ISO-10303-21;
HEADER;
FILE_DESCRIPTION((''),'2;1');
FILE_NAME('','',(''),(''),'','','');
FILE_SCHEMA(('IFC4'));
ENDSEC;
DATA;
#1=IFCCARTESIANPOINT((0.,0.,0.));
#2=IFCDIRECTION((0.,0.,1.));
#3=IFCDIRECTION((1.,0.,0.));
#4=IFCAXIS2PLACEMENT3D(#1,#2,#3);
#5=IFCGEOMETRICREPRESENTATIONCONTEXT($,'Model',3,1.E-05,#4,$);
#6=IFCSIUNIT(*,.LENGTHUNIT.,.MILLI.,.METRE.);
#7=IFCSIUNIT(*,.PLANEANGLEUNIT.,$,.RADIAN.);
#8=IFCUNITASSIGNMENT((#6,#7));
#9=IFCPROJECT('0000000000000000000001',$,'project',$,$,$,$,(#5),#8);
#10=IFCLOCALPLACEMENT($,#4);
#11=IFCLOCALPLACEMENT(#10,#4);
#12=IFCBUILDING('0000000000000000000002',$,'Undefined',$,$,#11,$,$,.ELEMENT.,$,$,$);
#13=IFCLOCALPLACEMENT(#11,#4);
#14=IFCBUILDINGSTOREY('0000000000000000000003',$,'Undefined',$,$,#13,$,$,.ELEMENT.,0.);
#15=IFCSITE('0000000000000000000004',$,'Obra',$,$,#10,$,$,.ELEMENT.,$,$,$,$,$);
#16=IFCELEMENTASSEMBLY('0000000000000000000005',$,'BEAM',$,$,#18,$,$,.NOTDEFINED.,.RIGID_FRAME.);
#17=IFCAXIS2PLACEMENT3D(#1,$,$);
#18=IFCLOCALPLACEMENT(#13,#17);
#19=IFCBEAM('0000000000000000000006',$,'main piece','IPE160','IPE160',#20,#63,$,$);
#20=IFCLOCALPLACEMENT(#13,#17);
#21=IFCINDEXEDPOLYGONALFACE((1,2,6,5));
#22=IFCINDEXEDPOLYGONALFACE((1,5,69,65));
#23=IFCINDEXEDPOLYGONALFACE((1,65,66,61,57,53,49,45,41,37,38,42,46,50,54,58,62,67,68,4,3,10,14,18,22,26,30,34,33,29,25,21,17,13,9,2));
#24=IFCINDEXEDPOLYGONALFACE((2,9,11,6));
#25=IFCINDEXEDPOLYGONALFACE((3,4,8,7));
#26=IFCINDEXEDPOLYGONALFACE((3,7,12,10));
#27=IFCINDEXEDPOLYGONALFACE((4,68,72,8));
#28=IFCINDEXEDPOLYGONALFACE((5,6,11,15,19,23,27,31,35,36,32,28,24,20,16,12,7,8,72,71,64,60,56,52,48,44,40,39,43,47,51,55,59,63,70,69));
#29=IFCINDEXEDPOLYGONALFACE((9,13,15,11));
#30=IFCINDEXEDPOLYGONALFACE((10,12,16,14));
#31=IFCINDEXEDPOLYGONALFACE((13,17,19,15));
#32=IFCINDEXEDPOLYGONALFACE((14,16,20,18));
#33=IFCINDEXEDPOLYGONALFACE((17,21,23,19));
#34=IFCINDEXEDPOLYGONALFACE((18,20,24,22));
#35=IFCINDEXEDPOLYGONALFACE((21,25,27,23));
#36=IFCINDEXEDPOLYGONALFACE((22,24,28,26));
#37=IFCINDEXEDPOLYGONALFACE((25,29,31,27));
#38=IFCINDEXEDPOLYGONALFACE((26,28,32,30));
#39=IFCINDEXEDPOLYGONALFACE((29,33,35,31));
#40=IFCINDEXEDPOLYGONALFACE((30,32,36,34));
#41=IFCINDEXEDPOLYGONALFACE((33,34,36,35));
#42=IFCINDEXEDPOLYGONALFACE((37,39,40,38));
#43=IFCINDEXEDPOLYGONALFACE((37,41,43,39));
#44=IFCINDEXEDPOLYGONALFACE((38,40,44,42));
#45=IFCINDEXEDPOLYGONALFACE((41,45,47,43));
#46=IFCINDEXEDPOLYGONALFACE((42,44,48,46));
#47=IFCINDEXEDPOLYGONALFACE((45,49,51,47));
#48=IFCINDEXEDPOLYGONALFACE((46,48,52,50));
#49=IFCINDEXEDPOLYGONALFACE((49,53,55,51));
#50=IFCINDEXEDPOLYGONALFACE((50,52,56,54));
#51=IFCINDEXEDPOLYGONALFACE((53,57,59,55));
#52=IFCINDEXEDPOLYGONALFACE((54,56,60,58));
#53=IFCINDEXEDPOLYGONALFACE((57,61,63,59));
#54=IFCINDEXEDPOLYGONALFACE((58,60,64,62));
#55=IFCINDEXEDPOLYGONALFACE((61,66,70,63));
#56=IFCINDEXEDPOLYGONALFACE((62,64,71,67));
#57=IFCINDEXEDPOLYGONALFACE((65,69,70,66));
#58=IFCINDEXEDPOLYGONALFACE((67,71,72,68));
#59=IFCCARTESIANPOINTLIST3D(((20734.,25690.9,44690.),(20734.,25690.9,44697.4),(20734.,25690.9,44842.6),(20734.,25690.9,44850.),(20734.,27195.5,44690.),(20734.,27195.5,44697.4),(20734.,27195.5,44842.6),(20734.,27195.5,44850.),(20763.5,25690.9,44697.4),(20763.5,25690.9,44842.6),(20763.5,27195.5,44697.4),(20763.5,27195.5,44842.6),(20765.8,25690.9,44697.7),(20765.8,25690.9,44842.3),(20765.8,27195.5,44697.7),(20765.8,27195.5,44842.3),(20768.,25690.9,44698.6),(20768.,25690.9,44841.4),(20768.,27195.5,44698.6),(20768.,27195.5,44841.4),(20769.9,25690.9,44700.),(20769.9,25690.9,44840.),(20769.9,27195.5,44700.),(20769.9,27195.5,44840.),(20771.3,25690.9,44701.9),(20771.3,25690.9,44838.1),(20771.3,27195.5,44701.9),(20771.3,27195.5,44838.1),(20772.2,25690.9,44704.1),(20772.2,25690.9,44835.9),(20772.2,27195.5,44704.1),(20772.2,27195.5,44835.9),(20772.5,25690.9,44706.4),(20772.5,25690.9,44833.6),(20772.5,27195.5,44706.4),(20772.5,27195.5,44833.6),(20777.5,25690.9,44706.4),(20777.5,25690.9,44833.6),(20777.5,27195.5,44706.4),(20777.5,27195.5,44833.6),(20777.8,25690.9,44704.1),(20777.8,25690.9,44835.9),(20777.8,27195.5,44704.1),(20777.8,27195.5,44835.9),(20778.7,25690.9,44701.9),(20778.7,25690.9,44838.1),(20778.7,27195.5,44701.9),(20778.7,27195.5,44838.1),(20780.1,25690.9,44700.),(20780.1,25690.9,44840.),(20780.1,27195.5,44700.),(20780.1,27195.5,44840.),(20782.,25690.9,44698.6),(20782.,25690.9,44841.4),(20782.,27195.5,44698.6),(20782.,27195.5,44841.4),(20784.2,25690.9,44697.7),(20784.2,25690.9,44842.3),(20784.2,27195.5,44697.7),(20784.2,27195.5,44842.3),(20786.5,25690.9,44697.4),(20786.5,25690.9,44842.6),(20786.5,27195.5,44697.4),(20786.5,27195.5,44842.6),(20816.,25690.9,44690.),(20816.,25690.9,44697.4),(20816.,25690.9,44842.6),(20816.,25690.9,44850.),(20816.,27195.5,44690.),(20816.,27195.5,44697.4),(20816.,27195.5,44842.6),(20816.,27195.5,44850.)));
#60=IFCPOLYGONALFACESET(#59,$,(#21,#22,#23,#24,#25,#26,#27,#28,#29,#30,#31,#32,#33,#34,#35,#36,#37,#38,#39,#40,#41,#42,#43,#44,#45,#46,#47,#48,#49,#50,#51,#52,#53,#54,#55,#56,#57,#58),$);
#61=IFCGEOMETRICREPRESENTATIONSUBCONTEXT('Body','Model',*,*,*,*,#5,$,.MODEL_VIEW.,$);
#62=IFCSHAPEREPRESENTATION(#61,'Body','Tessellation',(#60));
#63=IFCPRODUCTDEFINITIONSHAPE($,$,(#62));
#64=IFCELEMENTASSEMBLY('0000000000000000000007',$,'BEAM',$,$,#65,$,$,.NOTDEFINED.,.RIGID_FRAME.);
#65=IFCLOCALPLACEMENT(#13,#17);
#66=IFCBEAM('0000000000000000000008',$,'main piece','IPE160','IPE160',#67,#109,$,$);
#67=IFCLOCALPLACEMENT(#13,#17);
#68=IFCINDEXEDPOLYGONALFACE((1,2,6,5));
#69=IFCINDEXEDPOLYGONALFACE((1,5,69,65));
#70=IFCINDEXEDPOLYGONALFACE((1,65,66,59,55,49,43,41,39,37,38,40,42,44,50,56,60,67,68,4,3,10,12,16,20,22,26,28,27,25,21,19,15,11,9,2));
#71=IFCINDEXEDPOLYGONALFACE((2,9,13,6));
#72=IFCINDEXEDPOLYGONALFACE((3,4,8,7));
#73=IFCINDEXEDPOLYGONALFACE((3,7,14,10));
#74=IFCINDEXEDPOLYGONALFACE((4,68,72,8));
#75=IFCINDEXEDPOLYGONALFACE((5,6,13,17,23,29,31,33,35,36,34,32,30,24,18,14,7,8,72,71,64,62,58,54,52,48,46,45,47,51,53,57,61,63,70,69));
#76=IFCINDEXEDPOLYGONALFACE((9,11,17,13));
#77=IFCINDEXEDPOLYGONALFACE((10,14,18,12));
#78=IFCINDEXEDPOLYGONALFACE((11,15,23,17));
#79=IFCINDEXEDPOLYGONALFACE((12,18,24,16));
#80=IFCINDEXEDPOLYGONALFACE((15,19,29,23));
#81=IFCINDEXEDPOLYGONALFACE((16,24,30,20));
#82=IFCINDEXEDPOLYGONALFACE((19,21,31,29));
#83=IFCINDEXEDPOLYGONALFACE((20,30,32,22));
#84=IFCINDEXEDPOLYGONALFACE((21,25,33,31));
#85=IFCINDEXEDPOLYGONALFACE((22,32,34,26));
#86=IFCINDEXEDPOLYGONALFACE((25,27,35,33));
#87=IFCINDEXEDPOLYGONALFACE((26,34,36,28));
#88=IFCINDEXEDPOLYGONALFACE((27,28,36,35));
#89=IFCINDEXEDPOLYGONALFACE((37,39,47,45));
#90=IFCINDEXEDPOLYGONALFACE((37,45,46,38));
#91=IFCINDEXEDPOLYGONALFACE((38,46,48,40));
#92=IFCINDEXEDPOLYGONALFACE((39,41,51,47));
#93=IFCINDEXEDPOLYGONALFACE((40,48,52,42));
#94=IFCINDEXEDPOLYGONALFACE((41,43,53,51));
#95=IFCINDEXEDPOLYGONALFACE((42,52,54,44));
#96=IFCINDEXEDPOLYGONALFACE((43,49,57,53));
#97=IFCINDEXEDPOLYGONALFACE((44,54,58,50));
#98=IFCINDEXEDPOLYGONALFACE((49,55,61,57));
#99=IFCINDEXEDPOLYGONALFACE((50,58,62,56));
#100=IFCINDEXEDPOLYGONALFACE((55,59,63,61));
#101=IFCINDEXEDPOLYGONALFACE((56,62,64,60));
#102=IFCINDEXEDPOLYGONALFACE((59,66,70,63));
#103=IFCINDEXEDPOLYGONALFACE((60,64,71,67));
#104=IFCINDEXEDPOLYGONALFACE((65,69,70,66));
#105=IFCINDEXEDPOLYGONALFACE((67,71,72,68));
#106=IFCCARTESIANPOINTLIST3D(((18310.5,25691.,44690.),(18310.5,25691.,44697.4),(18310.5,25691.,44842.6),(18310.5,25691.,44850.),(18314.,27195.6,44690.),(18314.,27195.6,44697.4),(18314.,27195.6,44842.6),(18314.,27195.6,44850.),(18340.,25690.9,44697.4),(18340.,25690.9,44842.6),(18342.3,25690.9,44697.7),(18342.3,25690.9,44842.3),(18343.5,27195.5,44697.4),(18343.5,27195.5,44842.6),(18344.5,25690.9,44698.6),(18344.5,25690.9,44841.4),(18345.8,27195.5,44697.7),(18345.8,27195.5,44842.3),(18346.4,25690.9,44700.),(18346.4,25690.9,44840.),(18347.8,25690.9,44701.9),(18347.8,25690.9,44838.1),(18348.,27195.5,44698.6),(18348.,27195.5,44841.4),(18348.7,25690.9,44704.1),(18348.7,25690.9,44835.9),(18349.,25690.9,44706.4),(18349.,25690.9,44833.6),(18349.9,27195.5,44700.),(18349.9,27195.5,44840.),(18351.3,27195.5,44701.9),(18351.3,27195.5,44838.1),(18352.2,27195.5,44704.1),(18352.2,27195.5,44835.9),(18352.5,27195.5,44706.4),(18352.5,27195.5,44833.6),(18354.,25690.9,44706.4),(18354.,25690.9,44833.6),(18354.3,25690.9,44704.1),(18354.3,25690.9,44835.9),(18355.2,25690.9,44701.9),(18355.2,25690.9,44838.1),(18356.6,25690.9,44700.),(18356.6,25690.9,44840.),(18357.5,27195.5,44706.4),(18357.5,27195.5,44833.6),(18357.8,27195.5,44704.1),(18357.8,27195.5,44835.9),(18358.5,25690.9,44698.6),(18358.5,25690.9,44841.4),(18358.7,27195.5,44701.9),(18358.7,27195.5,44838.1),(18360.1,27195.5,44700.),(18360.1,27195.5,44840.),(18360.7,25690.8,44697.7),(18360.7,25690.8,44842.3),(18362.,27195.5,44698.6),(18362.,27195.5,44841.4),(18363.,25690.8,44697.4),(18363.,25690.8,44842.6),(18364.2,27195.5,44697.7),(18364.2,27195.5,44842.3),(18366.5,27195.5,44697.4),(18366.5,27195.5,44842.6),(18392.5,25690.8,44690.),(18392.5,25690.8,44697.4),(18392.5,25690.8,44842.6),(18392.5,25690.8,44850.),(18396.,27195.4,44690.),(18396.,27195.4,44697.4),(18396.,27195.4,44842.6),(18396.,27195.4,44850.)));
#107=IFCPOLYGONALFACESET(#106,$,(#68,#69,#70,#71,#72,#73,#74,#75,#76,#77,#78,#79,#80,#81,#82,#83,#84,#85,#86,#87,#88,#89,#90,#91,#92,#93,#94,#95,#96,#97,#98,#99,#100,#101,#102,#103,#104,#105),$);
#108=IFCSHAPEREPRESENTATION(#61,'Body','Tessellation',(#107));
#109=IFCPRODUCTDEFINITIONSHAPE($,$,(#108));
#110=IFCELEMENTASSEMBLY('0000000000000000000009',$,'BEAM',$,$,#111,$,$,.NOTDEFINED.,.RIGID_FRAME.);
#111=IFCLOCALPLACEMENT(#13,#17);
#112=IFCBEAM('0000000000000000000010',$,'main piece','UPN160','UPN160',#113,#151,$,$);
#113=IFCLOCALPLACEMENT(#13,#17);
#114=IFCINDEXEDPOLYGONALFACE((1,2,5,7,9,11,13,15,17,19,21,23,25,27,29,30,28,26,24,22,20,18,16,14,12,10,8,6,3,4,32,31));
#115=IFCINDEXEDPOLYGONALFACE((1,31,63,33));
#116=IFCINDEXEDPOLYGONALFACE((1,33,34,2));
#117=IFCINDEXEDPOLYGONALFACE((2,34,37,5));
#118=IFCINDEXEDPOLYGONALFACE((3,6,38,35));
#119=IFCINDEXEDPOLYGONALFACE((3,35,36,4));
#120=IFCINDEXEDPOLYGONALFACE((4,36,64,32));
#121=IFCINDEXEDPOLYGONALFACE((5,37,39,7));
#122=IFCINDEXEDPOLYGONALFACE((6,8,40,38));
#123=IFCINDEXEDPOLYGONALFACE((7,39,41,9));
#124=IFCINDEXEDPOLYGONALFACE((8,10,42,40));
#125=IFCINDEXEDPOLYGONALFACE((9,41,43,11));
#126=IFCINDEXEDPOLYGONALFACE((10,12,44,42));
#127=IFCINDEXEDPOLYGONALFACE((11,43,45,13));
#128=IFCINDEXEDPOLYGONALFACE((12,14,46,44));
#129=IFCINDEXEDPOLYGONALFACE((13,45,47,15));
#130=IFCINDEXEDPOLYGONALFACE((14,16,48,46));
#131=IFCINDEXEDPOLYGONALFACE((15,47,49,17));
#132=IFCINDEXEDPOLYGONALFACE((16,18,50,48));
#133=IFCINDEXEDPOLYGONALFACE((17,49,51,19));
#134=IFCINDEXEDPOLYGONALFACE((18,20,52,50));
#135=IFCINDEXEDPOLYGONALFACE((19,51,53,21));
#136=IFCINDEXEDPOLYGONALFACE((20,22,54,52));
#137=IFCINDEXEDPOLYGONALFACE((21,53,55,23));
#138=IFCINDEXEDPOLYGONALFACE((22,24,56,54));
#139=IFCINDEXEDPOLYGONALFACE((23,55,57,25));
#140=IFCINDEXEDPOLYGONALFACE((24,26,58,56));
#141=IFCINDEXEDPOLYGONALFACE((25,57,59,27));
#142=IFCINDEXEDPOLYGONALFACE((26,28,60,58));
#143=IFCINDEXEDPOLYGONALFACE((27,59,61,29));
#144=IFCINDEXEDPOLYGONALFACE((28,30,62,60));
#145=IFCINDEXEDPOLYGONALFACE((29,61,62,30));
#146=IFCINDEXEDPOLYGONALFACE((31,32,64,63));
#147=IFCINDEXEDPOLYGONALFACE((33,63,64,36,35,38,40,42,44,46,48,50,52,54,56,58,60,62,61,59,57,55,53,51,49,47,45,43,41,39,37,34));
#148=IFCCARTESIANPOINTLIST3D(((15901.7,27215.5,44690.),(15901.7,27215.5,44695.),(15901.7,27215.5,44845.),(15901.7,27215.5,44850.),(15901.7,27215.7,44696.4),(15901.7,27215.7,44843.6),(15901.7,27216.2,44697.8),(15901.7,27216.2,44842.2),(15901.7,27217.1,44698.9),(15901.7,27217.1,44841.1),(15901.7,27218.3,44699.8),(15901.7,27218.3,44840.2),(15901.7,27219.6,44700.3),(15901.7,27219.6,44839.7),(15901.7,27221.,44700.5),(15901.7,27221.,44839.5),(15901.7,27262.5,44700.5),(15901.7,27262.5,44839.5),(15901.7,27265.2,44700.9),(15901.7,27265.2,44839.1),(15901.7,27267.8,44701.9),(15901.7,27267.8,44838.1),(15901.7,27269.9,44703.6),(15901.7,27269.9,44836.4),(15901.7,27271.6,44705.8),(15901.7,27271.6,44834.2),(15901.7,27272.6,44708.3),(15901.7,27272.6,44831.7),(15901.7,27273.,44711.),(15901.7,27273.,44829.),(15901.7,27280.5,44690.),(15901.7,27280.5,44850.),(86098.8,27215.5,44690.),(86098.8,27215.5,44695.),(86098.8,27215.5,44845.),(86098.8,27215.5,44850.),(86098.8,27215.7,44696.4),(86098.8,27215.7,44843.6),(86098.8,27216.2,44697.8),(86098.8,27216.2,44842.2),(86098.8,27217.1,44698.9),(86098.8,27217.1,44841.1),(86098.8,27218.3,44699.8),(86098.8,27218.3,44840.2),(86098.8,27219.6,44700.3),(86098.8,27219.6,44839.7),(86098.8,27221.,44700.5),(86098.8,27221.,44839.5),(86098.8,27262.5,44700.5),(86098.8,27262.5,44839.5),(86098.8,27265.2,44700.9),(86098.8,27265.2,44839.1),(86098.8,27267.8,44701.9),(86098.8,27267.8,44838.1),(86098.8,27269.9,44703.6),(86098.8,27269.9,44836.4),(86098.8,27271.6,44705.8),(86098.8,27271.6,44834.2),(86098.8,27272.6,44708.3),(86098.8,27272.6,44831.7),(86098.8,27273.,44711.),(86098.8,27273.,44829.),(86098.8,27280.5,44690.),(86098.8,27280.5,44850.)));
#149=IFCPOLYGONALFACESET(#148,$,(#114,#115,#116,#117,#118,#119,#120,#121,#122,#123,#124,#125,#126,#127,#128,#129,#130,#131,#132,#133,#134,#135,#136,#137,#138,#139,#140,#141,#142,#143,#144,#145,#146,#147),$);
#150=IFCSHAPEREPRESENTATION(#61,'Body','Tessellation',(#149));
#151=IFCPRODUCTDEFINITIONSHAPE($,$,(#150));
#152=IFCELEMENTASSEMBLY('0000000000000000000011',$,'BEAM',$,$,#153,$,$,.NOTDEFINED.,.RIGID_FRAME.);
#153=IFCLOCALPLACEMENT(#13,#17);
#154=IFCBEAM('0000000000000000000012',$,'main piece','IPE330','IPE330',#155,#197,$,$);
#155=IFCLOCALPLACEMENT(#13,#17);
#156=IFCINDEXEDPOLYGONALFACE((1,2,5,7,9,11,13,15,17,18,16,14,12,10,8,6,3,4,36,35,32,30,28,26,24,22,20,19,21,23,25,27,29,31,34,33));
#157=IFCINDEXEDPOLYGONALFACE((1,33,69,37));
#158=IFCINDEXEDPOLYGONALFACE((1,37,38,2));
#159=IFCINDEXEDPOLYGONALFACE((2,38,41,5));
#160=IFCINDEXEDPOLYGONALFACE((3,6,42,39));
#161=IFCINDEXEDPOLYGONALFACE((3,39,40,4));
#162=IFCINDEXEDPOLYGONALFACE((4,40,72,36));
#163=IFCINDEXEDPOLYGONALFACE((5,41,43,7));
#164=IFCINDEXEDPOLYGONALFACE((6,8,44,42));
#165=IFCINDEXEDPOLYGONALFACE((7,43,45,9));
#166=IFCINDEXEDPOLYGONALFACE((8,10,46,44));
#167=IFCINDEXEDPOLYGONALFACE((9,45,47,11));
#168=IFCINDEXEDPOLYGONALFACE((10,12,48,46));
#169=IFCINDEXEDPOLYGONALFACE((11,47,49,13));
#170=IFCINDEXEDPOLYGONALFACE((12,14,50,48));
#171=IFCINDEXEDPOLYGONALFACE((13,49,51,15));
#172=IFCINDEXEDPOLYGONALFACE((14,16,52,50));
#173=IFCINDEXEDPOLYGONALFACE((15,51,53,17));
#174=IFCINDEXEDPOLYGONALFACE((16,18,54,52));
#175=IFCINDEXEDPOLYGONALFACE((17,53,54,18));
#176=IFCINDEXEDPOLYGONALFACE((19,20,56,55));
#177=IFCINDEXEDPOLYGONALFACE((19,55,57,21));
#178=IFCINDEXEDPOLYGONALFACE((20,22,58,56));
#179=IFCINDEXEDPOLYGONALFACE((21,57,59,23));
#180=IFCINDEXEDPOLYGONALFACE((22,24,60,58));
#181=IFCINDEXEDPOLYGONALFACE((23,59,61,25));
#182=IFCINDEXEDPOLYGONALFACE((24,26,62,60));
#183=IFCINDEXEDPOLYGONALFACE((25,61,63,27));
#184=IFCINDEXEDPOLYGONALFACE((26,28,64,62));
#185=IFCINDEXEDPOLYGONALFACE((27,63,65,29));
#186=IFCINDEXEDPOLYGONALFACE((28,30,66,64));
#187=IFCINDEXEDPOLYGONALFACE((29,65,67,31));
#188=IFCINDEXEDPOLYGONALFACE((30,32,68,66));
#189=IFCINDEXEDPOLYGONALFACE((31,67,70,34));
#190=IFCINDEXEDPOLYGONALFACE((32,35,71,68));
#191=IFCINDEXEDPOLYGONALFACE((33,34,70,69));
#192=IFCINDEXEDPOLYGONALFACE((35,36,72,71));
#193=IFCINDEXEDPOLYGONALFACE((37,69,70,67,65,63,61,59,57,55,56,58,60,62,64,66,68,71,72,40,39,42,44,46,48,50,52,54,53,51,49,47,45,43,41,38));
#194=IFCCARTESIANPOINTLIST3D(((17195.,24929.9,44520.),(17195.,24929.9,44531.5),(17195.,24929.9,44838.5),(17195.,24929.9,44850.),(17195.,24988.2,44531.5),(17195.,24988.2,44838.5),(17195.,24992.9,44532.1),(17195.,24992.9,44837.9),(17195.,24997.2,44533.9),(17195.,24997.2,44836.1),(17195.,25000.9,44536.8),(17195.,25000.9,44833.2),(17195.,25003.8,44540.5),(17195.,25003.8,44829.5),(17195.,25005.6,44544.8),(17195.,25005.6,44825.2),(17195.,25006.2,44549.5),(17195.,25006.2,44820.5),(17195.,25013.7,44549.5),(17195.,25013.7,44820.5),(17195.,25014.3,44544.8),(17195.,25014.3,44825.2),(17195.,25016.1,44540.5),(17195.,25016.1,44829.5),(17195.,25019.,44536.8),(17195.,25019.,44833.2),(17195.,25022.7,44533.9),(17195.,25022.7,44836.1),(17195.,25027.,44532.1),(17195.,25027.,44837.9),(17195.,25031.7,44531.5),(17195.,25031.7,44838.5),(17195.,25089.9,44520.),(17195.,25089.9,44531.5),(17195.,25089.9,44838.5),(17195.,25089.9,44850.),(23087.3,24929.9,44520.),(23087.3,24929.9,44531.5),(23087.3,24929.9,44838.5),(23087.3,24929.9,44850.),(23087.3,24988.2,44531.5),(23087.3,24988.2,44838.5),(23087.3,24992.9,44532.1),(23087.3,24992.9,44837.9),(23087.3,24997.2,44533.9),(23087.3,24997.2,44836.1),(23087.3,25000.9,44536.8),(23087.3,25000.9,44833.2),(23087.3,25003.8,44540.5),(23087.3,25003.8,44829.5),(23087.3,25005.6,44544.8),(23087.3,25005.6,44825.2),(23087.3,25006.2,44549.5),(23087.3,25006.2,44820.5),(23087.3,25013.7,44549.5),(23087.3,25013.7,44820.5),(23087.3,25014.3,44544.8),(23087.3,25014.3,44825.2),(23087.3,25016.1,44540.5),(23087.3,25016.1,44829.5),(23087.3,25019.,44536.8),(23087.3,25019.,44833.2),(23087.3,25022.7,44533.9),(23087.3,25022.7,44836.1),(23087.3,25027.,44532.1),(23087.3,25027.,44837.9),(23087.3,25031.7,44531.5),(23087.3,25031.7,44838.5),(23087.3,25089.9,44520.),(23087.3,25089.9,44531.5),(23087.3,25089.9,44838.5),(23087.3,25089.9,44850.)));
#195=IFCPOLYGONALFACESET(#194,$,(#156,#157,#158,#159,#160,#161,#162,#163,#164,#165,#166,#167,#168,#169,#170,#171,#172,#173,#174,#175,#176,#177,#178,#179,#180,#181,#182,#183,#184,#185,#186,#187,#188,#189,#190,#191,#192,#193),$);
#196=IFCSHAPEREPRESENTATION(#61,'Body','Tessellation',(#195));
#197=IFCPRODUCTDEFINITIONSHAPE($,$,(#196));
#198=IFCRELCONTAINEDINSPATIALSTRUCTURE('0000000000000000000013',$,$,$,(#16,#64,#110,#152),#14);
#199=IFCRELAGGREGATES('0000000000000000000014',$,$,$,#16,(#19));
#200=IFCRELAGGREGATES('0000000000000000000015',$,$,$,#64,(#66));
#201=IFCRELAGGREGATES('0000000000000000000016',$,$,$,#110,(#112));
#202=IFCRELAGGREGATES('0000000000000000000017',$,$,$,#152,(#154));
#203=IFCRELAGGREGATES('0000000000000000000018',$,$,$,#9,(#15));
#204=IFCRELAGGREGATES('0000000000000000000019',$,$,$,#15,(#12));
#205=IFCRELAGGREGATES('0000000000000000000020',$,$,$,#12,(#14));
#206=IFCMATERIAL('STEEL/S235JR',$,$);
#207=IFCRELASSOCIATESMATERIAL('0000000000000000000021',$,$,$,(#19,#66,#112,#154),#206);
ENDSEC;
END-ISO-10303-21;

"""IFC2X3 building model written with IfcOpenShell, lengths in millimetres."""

from ifc_helpers import new_model, si_unit, frame, origin_with_axes, origin_2d_with_axis, place, context, subcontext, project, spatial, i_section, u_section, extrude, material, element, aggregate, save


model = new_model("IFC2X3")

# Units and contexts
model_context = context("Model", 3, precision=1e-05, world=origin_with_axes())
body_context = subcontext(model_context, "Body", "Model", "MODEL_VIEW")
ifc_project = project(units=[si_unit("LENGTHUNIT", "METRE", prefix="MILLI"), si_unit("PLANEANGLEUNIT", "RADIAN")], contexts=[model_context])

# Site, building, storey
site_placement = place(None, origin_with_axes())
site = spatial("IfcSite", under=ifc_project, at=site_placement, Name="Obra", CompositionType="ELEMENT")
building_placement = place(site_placement, origin_with_axes())
building = spatial("IfcBuilding", under=site, at=building_placement, Name="Undefined", CompositionType="ELEMENT")
storey_placement = place(building_placement, origin_with_axes())
storey = spatial("IfcBuildingStorey", under=building, at=storey_placement, Name="Undefined", CompositionType="ELEMENT", Elevation=0.0)

# Shared definitions
ifc_material_1 = material(Name="STEEL/S235JR")

# Element assemblies, beams
assembly_1_placement = place(storey_placement, origin_with_axes())
assembly_1 = element("IfcElementAssembly", 1, at=assembly_1_placement, inside=storey, Name="BEAM", AssemblyPlace="NOTDEFINED", PredefinedType="RIGID_FRAME")
beam_1_placement = place(assembly_1_placement, frame((20775.0, 25690.9, 44770.0), z_axis=(0.0, 0.0, 1.0), x_axis=(0.0, 1.0, 0.0)))
beam_1 = element("IfcBeam", 2, at=beam_1_placement, material=ifc_material_1, Name="main piece", Description="IPE160", ObjectType="IPE160", context=body_context, shape_type="SweptSolid", body=[
    extrude(i_section(OverallWidth=82.0, OverallDepth=160.0, WebThickness=5.0, FlangeThickness=7.4, FilletRadius=9.0, at=origin_2d_with_axis()), frame((1504.6, 0.0, 0.0), z_axis=(-1.0, 0.0, 0.0), x_axis=(0.0, -1.0, 0.0)), (0.0, 0.0, 1.0), 1504.6),
])
aggregate(assembly_1, [beam_1])
assembly_2_placement = place(storey_placement, origin_with_axes())
assembly_2 = element("IfcElementAssembly", 3, at=assembly_2_placement, inside=storey, Name="BEAM", AssemblyPlace="NOTDEFINED", PredefinedType="RIGID_FRAME")
beam_2_placement = place(assembly_2_placement, frame((18351.5, 25690.9, 44770.0), z_axis=(0.0, 0.0, 1.0), x_axis=(0.002325, 0.999997, 0.0)))
beam_2 = element("IfcBeam", 4, at=beam_2_placement, material=ifc_material_1, Name="main piece", Description="IPE160", ObjectType="IPE160", context=body_context, shape_type="SweptSolid", body=[
    extrude(i_section(OverallWidth=82.0, OverallDepth=160.0, WebThickness=5.0, FlangeThickness=7.4, FilletRadius=9.0, at=origin_2d_with_axis()), frame((1504.6, 0.0, 0.0), z_axis=(-1.0, 0.0, 0.0), x_axis=(0.0, -1.0, 0.0)), (0.0, 0.0, 1.0), 1504.6),
])
aggregate(assembly_2, [beam_2])
assembly_3_placement = place(storey_placement, origin_with_axes())
assembly_3 = element("IfcElementAssembly", 5, at=assembly_3_placement, inside=storey, Name="BEAM", AssemblyPlace="NOTDEFINED", PredefinedType="RIGID_FRAME")
beam_3_placement = place(assembly_3_placement, frame((15901.7, 27248.0, 44770.0), z_axis=(0.0, 0.0, 1.0), x_axis=(1.0, 0.0, 0.0)))
beam_3 = element("IfcBeam", 6, at=beam_3_placement, material=ifc_material_1, Name="main piece", Description="UPN160", ObjectType="UPN160", context=body_context, shape_type="SweptSolid", body=[
    extrude(u_section(Depth=160.0, FlangeWidth=65.0, WebThickness=7.5, FlangeThickness=10.5, FilletRadius=10.5, EdgeRadius=5.5, at=origin_2d_with_axis()), frame((70197.1, 0.0, 0.0), z_axis=(-1.0, 0.0, 0.0), x_axis=(0.0, -1.0, 0.0)), (0.0, 0.0, 1.0), 70197.1),
])
aggregate(assembly_3, [beam_3])
assembly_4_placement = place(storey_placement, origin_with_axes())
assembly_4 = element("IfcElementAssembly", 7, at=assembly_4_placement, inside=storey, Name="BEAM", AssemblyPlace="NOTDEFINED", PredefinedType="RIGID_FRAME")
beam_4_placement = place(assembly_4_placement, frame((17195.0, 25009.9, 44685.0), z_axis=(0.0, 0.0, 1.0), x_axis=(1.0, 0.0, 0.0)))
beam_4 = element("IfcBeam", 8, at=beam_4_placement, material=ifc_material_1, Name="main piece", Description="IPE330", ObjectType="IPE330", context=body_context, shape_type="SweptSolid", body=[
    extrude(i_section(OverallWidth=160.0, OverallDepth=330.0, WebThickness=7.5, FlangeThickness=11.5, FilletRadius=18.0, at=origin_2d_with_axis()), frame((5892.3, 0.0, 0.0), z_axis=(-1.0, 0.0, 0.0), x_axis=(0.0, -1.0, 0.0)), (0.0, 0.0, 1.0), 5892.3),
])
aggregate(assembly_4, [beam_4])

save(model, "model.ifc")
